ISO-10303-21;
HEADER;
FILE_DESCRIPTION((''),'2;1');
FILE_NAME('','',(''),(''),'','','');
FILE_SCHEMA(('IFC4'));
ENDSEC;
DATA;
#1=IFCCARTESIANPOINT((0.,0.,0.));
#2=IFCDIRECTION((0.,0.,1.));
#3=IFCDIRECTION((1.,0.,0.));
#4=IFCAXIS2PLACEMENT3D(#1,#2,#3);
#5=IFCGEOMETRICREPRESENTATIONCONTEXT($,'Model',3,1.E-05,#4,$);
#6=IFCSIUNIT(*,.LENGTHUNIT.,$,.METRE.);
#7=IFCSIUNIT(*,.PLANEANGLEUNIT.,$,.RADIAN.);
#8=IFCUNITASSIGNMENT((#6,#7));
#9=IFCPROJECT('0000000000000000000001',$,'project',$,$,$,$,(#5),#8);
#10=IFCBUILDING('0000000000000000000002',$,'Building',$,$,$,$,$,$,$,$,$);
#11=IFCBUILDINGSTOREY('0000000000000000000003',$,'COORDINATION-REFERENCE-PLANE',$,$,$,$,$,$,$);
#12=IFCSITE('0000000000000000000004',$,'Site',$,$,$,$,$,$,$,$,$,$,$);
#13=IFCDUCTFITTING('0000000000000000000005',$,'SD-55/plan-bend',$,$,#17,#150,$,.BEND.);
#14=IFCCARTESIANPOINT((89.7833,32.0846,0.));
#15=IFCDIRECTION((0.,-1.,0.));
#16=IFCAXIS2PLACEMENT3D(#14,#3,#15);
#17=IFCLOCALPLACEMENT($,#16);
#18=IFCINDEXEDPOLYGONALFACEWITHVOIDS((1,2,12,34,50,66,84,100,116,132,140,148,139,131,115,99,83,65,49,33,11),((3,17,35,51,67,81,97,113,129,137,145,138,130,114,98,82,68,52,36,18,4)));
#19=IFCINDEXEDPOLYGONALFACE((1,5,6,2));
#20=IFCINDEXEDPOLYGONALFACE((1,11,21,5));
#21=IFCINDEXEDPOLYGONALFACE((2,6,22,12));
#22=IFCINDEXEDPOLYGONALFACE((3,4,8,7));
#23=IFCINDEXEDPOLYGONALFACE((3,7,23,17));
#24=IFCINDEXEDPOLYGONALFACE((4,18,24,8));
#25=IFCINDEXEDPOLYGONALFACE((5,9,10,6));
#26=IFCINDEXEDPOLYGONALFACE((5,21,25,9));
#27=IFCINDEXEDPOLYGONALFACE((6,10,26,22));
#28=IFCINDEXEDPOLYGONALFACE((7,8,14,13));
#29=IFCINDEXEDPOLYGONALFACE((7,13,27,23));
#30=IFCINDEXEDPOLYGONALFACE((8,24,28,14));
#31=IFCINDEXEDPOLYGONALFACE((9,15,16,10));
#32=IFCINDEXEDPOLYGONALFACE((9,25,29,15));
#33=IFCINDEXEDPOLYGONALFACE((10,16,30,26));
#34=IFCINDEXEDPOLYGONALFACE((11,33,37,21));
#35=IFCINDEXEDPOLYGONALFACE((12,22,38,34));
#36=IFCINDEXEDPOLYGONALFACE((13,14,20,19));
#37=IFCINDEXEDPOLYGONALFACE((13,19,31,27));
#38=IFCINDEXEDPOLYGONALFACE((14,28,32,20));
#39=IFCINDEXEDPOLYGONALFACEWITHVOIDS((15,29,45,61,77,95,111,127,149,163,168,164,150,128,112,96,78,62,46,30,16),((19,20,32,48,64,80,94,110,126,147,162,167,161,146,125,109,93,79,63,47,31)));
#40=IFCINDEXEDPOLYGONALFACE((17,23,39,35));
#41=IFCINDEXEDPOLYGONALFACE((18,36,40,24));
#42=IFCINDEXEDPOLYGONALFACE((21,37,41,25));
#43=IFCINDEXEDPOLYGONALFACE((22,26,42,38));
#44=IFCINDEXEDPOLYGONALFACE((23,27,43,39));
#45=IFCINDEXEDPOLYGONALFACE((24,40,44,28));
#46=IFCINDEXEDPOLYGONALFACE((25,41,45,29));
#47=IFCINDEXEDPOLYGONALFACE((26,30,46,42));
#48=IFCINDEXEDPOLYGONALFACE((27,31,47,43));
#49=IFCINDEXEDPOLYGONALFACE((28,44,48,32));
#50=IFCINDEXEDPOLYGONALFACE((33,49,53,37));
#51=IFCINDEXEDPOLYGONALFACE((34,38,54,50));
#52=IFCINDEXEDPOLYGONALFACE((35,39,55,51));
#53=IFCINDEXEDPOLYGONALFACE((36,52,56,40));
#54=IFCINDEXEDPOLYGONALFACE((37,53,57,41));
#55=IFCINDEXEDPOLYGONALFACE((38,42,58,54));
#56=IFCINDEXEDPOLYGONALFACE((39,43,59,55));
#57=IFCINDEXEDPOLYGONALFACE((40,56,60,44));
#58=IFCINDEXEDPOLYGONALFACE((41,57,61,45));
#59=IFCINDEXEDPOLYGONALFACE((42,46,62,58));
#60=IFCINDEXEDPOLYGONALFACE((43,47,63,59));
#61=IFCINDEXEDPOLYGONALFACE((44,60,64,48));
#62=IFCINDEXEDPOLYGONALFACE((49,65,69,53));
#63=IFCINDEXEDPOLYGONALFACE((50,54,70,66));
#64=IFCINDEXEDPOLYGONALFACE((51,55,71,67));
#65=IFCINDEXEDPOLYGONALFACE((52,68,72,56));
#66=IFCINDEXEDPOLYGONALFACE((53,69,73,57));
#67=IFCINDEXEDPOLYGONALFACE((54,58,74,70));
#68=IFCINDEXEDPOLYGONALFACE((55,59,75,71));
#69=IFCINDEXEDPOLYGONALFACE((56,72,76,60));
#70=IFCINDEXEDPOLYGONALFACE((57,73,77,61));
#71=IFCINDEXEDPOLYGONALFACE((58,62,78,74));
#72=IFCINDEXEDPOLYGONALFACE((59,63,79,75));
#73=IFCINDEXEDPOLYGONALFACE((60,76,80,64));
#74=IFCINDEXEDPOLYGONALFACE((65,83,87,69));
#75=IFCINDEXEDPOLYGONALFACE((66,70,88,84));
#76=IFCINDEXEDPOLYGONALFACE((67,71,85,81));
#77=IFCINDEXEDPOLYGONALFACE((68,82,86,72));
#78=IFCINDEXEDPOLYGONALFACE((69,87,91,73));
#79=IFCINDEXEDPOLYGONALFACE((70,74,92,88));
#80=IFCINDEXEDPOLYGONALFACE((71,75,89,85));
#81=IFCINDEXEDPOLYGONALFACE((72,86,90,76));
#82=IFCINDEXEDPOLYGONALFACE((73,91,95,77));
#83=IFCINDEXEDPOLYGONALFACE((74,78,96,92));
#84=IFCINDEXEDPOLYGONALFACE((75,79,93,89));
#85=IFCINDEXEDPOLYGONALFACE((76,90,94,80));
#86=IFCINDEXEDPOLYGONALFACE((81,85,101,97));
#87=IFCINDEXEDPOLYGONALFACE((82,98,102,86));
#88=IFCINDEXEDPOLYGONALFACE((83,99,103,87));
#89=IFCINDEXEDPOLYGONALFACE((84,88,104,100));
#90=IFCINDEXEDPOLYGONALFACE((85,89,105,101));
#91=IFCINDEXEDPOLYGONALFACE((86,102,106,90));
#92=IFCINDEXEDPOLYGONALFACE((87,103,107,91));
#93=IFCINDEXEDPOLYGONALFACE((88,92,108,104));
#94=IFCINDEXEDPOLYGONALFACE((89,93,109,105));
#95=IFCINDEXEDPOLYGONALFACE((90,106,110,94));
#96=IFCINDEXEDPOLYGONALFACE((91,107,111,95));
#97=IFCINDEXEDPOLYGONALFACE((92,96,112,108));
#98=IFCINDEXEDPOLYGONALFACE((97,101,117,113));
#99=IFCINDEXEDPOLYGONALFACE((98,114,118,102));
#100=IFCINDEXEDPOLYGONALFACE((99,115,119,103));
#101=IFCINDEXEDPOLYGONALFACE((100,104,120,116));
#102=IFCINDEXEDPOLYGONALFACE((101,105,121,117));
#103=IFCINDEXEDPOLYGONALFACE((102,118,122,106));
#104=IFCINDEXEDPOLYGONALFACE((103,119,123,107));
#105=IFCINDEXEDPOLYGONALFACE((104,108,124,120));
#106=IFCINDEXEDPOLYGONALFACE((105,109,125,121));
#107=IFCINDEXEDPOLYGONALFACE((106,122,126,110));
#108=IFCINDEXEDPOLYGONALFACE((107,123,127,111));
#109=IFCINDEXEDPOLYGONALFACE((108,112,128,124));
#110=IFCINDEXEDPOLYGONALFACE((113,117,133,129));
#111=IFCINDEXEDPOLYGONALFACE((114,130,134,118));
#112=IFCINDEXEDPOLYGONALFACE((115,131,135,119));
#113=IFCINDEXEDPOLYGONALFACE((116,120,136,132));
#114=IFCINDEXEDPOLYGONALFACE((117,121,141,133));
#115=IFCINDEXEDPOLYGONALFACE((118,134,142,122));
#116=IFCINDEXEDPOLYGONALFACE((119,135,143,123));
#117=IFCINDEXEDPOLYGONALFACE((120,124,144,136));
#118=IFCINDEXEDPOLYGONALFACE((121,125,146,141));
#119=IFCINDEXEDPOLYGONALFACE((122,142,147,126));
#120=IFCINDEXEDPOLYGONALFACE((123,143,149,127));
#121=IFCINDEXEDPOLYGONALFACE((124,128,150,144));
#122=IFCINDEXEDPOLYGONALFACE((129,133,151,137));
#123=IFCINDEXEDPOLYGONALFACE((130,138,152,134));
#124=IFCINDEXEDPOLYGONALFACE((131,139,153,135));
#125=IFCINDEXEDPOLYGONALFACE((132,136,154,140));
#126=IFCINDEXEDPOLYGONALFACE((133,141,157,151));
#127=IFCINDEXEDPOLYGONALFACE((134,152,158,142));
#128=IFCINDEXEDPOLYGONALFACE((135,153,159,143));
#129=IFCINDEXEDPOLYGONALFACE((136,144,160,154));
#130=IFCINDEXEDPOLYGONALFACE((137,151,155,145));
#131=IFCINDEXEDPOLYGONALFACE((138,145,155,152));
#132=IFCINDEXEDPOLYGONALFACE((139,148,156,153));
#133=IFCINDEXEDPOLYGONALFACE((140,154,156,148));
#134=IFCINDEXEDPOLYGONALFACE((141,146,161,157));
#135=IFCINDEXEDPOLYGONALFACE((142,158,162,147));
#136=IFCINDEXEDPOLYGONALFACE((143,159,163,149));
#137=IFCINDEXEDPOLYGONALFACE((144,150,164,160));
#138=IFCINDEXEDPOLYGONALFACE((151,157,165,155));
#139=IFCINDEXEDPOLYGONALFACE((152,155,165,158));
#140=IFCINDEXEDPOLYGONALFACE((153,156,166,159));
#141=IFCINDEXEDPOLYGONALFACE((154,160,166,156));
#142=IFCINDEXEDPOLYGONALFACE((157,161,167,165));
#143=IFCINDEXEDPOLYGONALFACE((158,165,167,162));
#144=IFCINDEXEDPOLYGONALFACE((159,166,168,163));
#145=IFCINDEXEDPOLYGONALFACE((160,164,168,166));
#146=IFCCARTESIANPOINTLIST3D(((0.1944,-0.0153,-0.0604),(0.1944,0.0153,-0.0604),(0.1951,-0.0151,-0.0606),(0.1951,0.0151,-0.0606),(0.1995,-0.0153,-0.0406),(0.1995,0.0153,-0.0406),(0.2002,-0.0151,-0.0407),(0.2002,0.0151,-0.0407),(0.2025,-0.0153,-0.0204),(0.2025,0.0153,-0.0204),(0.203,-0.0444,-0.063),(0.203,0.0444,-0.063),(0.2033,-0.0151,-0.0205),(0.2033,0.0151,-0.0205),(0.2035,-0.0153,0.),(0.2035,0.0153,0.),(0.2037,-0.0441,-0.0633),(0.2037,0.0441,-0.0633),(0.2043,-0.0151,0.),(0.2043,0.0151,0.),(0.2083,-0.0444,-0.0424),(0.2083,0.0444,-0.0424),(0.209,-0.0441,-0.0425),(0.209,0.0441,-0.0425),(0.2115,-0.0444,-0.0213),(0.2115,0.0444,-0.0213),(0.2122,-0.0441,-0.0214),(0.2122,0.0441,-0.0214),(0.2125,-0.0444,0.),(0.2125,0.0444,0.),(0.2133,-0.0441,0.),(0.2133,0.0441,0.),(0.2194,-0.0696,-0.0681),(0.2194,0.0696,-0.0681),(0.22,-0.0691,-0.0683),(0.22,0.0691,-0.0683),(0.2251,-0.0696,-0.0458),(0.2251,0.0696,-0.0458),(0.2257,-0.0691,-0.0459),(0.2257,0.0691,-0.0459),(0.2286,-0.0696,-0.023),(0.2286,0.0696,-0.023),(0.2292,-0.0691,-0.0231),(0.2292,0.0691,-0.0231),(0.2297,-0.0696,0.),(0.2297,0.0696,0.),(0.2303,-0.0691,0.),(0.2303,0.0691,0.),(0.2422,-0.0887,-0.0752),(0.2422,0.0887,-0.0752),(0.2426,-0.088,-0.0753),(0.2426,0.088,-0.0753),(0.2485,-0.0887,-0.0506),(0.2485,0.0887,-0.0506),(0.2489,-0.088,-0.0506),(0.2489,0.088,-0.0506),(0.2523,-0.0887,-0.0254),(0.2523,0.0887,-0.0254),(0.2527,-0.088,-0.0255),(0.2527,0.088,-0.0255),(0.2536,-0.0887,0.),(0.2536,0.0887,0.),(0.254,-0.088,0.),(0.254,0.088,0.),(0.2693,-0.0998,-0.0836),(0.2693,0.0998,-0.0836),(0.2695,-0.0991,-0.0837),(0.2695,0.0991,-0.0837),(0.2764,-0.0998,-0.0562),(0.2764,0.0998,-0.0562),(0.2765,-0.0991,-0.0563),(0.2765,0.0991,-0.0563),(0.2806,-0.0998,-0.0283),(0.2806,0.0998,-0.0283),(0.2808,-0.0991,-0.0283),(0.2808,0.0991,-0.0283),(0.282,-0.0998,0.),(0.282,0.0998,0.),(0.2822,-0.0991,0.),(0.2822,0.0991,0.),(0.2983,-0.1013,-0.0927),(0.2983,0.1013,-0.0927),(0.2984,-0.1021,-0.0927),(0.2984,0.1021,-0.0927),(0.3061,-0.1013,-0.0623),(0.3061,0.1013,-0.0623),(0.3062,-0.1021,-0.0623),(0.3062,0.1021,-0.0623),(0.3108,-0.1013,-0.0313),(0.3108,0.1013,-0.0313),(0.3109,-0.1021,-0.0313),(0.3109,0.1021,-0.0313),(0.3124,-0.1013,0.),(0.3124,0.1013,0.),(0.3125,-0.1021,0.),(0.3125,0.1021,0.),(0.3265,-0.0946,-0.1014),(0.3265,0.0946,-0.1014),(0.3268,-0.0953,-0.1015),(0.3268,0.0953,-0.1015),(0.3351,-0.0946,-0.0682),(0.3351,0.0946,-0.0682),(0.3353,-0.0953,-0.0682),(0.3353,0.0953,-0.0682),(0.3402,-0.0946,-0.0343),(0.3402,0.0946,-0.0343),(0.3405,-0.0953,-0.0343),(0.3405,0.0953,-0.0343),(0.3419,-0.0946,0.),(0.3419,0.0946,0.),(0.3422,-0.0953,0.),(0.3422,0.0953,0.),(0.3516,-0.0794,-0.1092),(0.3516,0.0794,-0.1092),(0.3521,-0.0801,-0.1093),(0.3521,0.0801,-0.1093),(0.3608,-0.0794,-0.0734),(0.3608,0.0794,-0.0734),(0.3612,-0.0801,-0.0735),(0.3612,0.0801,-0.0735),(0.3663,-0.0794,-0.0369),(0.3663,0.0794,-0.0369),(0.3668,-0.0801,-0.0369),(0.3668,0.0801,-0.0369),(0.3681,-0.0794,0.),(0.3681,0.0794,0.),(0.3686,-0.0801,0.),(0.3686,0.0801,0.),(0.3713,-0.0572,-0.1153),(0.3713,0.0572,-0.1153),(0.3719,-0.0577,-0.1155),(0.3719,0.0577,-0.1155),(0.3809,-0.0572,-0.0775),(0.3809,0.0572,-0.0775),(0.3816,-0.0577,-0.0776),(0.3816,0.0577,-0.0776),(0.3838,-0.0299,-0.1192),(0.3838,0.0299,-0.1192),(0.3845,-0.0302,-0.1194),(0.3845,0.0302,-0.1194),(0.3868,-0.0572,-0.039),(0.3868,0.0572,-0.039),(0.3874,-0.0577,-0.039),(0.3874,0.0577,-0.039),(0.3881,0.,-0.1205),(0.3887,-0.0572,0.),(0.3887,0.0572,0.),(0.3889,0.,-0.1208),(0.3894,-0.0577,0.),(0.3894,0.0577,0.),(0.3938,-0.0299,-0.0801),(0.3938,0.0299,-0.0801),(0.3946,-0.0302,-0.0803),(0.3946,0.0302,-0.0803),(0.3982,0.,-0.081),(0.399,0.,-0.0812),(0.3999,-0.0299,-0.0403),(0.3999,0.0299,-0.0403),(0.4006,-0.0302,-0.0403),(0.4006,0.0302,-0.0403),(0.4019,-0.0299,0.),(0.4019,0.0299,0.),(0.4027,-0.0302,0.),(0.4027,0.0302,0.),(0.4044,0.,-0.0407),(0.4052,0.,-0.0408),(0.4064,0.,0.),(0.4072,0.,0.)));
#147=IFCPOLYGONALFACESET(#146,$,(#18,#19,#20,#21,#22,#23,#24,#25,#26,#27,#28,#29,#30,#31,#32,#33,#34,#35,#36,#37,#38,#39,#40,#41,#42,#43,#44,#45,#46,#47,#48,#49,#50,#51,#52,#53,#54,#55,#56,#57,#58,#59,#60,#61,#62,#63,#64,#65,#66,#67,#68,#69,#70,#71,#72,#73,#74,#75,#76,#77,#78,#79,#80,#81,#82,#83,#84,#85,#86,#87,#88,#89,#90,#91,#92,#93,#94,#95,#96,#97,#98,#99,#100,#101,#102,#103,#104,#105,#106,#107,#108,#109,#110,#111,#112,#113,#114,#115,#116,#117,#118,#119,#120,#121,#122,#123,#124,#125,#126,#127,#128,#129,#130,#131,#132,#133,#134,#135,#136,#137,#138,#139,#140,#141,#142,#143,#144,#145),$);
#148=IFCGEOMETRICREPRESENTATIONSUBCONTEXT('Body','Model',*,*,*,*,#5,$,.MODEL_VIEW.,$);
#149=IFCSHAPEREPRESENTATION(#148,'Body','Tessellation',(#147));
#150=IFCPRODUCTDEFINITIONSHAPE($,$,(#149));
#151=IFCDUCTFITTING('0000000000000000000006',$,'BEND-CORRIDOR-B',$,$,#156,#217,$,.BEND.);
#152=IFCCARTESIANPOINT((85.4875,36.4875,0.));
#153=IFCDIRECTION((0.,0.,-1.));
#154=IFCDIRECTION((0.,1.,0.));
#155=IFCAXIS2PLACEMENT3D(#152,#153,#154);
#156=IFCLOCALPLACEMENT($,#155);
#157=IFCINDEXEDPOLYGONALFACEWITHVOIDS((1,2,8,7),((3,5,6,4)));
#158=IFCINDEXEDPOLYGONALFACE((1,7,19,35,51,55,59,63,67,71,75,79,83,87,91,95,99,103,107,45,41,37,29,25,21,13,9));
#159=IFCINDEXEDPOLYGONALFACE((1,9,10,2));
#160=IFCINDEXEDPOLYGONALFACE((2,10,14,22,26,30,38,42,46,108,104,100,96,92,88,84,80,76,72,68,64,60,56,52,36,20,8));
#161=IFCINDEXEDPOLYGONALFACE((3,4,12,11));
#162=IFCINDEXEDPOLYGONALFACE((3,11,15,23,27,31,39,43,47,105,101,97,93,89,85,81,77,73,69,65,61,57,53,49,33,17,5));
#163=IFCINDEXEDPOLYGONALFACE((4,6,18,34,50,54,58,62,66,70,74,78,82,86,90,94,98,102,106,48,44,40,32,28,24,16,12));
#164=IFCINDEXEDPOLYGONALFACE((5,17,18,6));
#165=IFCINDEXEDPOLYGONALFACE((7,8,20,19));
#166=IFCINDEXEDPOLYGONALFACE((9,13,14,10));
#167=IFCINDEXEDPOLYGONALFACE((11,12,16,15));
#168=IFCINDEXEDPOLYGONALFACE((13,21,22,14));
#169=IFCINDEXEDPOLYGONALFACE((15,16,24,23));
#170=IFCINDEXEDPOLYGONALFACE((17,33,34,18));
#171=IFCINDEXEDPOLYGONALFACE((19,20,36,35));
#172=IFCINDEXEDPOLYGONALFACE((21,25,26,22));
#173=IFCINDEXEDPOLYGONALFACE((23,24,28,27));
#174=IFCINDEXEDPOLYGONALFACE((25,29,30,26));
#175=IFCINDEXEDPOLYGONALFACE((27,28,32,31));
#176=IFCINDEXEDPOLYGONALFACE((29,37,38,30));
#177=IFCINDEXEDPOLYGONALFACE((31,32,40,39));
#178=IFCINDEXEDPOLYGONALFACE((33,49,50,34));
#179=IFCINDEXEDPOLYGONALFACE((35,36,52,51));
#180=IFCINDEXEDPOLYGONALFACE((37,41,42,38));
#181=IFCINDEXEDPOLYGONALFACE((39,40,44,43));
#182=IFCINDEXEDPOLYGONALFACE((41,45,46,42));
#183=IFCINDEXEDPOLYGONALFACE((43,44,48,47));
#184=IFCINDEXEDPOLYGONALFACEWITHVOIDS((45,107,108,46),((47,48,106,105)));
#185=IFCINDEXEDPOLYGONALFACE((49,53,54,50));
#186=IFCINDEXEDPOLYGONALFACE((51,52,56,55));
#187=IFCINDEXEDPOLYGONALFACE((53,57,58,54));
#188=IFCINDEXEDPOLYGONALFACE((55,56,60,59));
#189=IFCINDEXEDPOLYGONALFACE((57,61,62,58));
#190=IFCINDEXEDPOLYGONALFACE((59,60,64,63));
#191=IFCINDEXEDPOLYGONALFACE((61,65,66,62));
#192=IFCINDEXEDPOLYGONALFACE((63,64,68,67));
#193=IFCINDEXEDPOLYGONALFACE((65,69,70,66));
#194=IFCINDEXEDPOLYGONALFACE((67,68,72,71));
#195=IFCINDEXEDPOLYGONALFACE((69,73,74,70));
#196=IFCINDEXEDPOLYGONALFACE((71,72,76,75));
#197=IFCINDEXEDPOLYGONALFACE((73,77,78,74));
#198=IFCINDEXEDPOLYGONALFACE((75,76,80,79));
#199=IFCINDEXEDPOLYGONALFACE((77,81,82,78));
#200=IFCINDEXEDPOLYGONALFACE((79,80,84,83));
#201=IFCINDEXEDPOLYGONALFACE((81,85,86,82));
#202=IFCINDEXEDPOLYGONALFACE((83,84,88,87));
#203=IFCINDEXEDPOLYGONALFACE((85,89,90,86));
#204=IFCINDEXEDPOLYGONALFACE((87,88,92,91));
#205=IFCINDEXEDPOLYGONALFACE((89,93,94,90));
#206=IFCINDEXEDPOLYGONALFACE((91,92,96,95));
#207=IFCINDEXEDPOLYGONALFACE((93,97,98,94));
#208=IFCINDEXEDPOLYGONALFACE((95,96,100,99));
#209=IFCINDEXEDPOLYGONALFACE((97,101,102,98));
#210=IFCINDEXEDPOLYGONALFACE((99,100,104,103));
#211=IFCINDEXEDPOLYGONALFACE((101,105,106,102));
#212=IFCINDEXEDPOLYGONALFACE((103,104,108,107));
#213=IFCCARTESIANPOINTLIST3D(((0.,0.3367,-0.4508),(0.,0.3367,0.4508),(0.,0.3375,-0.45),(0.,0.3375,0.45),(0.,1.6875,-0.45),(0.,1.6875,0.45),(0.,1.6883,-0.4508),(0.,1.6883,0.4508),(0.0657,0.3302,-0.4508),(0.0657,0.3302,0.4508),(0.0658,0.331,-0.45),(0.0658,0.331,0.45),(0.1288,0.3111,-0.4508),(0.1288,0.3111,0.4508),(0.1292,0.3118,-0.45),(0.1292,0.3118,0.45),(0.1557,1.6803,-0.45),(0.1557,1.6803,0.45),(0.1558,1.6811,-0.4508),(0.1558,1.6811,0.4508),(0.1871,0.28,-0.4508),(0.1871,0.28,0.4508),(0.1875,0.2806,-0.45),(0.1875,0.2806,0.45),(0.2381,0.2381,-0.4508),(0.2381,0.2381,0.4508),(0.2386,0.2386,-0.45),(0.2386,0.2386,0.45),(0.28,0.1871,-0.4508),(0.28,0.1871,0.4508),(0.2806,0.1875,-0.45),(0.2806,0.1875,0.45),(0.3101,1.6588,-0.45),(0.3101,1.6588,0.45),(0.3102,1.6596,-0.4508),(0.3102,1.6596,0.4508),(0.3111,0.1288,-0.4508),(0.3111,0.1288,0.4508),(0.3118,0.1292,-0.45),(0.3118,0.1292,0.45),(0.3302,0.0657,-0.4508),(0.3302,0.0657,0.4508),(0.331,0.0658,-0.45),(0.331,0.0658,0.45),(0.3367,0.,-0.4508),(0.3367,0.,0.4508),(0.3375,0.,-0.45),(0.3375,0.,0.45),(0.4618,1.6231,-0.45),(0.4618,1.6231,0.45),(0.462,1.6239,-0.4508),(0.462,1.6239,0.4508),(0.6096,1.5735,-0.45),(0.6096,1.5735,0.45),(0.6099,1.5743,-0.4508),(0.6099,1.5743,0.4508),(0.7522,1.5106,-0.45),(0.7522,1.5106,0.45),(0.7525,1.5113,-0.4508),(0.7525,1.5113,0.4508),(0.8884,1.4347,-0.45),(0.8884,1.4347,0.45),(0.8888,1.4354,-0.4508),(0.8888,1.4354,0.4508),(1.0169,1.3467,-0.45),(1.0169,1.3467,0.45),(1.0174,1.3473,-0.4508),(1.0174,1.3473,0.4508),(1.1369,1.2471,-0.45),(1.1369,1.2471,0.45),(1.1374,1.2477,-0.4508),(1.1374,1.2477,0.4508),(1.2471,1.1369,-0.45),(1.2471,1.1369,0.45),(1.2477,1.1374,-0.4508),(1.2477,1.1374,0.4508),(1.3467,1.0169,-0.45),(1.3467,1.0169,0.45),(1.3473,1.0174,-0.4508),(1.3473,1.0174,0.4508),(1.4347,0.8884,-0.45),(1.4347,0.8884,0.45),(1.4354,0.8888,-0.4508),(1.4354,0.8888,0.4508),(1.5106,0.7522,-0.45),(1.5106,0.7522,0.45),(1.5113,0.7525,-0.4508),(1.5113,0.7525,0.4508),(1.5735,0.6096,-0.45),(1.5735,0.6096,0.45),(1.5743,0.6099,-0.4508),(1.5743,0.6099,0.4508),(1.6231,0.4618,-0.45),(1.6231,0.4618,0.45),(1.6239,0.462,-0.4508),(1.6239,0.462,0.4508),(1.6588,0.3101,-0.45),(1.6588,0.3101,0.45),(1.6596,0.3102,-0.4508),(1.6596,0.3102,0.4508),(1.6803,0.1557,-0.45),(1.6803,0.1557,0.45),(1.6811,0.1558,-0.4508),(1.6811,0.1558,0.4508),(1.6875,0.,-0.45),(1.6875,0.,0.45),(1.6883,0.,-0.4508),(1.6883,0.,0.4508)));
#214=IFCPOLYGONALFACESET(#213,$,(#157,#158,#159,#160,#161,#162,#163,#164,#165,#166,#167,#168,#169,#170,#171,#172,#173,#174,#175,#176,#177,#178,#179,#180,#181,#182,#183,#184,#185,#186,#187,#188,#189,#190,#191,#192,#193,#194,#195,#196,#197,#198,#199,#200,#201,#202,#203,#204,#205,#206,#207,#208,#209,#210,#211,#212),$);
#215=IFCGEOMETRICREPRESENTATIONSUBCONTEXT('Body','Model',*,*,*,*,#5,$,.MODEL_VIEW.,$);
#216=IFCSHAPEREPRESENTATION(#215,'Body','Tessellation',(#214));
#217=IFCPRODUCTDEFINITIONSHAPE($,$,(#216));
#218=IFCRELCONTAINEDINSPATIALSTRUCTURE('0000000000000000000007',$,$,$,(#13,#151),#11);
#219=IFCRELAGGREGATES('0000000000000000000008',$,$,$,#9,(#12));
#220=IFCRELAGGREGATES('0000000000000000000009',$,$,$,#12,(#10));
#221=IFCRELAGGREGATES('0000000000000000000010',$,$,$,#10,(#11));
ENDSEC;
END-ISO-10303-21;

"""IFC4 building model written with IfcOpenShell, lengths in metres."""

from ifc_helpers import new_model, entity, si_unit, frame, origin_with_axes, place, context, subcontext, project, spatial, element, save


model = new_model("IFC4")

# Units and contexts
model_context = context("Model", 3, precision=1e-05, world=origin_with_axes())
body_context_1 = subcontext(model_context, "Body", "Model", "MODEL_VIEW")
body_context_2 = subcontext(model_context, "Body", "Model", "MODEL_VIEW")
ifc_project = project(units=[si_unit("LENGTHUNIT", "METRE"), si_unit("PLANEANGLEUNIT", "RADIAN")], contexts=[model_context])

# Site, building, storey
site = spatial("IfcSite", under=ifc_project, Name="Site")
building = spatial("IfcBuilding", under=site, Name="Building")
storey = spatial("IfcBuildingStorey", under=building, Name="COORDINATION-REFERENCE-PLANE")

# Duct fitting
duct_fitting_1_placement = place(None, frame((89.7833, 32.0846, 0.0), z_axis=(1.0, 0.0, 0.0), x_axis=(0.0, -1.0, 0.0)))
element("IfcDuctFitting", 1, at=duct_fitting_1_placement, inside=storey, Name="SD-55/plan-bend", PredefinedType="BEND", context=body_context_1, shape_type="SweptSolid", body=[
    entity("IfcRevolvedAreaSolid", entity("IfcCircleHollowProfileDef", "AREA", None, entity("IfcAxis2Placement2D", entity("IfcCartesianPoint", [0.3048, 0.0])), 0.1024, 0.0008), entity("IfcAxis2Placement3D", entity("IfcCartesianPoint", [0.0, 0.0, 0.0]), entity("IfcDirection", [0.0, 0.0, 1.0]), entity("IfcDirection", [1.0, 0.0, 0.0])), entity("IfcAxis1Placement", entity("IfcCartesianPoint", [0.0, 0.0, 0.0]), entity("IfcDirection", [0.0, 1.0, 0.0])), 0.301119),
])

# Duct fitting
duct_fitting_2_placement = place(None, frame((85.4875, 36.4875, 0.0), z_axis=(0.0, 0.0, -1.0), x_axis=(0.0, 1.0, 0.0)))
cartesian_point_1 = entity("IfcCartesianPoint", [0.0, 0.0, 0.0])
element("IfcDuctFitting", 2, at=duct_fitting_2_placement, inside=storey, Name="BEND-CORRIDOR-B", PredefinedType="BEND", context=body_context_2, shape_type="SweptSolid", body=[
    entity("IfcRevolvedAreaSolid", entity("IfcRectangleHollowProfileDef", "AREA", None, entity("IfcAxis2Placement2D", entity("IfcCartesianPoint", [1.0125, 0.0])), 1.3516, 0.9016, 0.0008), entity("IfcAxis2Placement3D", cartesian_point_1, entity("IfcDirection", [0.0, -1.0, 0.0]), entity("IfcDirection", [1.0, 0.0, 0.0])), entity("IfcAxis1Placement", cartesian_point_1, entity("IfcDirection", [0.0, 1.0, 0.0])), 1.570796),
])

save(model, "model.ifc")
